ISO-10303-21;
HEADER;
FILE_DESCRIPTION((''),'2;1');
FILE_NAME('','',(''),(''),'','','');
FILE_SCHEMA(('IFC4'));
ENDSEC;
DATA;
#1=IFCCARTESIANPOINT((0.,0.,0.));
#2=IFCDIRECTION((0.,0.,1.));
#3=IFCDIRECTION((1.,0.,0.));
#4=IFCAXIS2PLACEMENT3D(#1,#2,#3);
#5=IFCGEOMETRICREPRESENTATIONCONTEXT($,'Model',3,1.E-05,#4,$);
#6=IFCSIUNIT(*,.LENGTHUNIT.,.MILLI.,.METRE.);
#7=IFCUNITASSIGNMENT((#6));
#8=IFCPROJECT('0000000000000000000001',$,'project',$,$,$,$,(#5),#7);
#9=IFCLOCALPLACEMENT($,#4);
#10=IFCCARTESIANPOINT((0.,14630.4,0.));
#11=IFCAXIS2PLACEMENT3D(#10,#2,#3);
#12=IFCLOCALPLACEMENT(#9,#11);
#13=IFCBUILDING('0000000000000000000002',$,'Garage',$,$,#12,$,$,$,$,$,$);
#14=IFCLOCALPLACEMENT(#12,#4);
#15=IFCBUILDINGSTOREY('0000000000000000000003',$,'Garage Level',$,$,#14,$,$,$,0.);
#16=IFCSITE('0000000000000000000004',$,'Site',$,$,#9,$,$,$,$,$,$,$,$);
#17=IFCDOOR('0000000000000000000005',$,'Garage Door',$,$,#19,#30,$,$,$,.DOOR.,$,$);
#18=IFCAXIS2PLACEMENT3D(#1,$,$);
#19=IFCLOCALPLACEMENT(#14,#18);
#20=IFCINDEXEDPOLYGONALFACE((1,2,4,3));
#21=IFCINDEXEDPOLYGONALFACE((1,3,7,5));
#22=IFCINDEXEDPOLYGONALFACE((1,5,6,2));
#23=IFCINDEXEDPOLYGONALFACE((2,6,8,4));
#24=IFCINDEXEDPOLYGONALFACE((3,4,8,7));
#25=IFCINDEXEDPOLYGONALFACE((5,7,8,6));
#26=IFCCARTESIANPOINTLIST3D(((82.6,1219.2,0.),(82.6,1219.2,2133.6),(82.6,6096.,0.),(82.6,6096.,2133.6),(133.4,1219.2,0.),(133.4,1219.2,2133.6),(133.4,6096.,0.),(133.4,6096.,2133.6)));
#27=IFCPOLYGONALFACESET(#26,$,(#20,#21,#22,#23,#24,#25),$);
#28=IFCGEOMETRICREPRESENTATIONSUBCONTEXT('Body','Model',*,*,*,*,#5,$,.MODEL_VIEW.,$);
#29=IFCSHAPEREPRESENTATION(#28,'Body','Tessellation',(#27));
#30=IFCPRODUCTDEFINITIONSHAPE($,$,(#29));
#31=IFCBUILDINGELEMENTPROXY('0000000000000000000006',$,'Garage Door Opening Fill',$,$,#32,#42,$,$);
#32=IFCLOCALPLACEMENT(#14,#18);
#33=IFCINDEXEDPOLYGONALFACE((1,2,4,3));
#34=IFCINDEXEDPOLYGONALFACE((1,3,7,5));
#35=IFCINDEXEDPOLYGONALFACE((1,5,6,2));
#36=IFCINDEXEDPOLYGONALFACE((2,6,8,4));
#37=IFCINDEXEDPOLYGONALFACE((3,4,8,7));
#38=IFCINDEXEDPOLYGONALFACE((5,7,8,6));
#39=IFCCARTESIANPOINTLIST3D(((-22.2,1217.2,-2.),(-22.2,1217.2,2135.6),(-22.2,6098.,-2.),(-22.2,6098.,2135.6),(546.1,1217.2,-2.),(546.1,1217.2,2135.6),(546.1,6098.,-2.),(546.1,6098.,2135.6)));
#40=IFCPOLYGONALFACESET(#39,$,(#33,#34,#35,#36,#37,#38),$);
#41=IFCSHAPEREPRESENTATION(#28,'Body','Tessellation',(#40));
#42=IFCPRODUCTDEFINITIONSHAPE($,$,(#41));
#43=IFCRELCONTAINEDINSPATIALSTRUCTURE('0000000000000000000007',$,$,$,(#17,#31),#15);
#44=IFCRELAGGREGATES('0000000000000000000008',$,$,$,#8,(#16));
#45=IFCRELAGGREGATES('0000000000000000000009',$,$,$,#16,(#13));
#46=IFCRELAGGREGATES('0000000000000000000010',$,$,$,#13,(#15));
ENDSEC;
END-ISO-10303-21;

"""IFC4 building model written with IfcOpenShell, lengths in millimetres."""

from ifc_helpers import new_model, si_unit, frame, origin_with_axes, place, context, subcontext, project, spatial, indexed_curve, outline, extrude, element, save


model = new_model("IFC4")

# Units and contexts
model_context = context("Model", 3, precision=1e-05, world=origin_with_axes())
body_context = subcontext(model_context, "Body", "Model", "MODEL_VIEW")
ifc_project = project(units=[si_unit("LENGTHUNIT", "METRE", prefix="MILLI")], contexts=[model_context])

# Site, building, storey
site_placement = place(None, origin_with_axes())
site = spatial("IfcSite", under=ifc_project, at=site_placement, Name="Site")
building_placement = place(site_placement, frame((0.0, 14630.4, 0.0), z_axis=(0.0, 0.0, 1.0), x_axis=(1.0, 0.0, 0.0)))
building = spatial("IfcBuilding", under=site, at=building_placement, Name="Garage")
storey_placement = place(building_placement, origin_with_axes())
storey = spatial("IfcBuildingStorey", under=building, at=storey_placement, Name="Garage Level", Elevation=0.0)

# Door
door_placement = place(storey_placement, frame((82.5, 7315.2, 0.0), z_axis=(1.0, 0.0, 0.0), x_axis=(0.0, -1.0, 0.0)))
element("IfcDoor", 1, at=door_placement, inside=storey, Name="Garage Door", PredefinedType="DOOR", context=body_context, shape_type="SweptSolid", body=[
    extrude(outline(indexed_curve([(1219.2, 0.0), (6096.0, 0.0), (6096.0, -2133.6), (1219.2, -2133.6), (1219.2, 0.0)])), origin_with_axes(), (0.0, 0.0, 1.0), 50.8),
])

# Building element proxy
proxy_placement = place(storey_placement, frame((-22.2, 7315.2, 0.0), z_axis=(1.0, 0.0, 0.0), x_axis=(0.0, -1.0, 0.0)))
element("IfcBuildingElementProxy", 2, at=proxy_placement, inside=storey, Name="Garage Door Opening Fill", context=body_context, shape_type="SweptSolid", body=[
    extrude(outline(indexed_curve([(1217.2, 2.0), (6098.0, 2.0), (6098.0, -2135.6), (1217.2, -2135.6), (1217.2, 2.0)])), origin_with_axes(), (0.0, 0.0, 1.0), 568.3),
])

save(model, "model.ifc")
